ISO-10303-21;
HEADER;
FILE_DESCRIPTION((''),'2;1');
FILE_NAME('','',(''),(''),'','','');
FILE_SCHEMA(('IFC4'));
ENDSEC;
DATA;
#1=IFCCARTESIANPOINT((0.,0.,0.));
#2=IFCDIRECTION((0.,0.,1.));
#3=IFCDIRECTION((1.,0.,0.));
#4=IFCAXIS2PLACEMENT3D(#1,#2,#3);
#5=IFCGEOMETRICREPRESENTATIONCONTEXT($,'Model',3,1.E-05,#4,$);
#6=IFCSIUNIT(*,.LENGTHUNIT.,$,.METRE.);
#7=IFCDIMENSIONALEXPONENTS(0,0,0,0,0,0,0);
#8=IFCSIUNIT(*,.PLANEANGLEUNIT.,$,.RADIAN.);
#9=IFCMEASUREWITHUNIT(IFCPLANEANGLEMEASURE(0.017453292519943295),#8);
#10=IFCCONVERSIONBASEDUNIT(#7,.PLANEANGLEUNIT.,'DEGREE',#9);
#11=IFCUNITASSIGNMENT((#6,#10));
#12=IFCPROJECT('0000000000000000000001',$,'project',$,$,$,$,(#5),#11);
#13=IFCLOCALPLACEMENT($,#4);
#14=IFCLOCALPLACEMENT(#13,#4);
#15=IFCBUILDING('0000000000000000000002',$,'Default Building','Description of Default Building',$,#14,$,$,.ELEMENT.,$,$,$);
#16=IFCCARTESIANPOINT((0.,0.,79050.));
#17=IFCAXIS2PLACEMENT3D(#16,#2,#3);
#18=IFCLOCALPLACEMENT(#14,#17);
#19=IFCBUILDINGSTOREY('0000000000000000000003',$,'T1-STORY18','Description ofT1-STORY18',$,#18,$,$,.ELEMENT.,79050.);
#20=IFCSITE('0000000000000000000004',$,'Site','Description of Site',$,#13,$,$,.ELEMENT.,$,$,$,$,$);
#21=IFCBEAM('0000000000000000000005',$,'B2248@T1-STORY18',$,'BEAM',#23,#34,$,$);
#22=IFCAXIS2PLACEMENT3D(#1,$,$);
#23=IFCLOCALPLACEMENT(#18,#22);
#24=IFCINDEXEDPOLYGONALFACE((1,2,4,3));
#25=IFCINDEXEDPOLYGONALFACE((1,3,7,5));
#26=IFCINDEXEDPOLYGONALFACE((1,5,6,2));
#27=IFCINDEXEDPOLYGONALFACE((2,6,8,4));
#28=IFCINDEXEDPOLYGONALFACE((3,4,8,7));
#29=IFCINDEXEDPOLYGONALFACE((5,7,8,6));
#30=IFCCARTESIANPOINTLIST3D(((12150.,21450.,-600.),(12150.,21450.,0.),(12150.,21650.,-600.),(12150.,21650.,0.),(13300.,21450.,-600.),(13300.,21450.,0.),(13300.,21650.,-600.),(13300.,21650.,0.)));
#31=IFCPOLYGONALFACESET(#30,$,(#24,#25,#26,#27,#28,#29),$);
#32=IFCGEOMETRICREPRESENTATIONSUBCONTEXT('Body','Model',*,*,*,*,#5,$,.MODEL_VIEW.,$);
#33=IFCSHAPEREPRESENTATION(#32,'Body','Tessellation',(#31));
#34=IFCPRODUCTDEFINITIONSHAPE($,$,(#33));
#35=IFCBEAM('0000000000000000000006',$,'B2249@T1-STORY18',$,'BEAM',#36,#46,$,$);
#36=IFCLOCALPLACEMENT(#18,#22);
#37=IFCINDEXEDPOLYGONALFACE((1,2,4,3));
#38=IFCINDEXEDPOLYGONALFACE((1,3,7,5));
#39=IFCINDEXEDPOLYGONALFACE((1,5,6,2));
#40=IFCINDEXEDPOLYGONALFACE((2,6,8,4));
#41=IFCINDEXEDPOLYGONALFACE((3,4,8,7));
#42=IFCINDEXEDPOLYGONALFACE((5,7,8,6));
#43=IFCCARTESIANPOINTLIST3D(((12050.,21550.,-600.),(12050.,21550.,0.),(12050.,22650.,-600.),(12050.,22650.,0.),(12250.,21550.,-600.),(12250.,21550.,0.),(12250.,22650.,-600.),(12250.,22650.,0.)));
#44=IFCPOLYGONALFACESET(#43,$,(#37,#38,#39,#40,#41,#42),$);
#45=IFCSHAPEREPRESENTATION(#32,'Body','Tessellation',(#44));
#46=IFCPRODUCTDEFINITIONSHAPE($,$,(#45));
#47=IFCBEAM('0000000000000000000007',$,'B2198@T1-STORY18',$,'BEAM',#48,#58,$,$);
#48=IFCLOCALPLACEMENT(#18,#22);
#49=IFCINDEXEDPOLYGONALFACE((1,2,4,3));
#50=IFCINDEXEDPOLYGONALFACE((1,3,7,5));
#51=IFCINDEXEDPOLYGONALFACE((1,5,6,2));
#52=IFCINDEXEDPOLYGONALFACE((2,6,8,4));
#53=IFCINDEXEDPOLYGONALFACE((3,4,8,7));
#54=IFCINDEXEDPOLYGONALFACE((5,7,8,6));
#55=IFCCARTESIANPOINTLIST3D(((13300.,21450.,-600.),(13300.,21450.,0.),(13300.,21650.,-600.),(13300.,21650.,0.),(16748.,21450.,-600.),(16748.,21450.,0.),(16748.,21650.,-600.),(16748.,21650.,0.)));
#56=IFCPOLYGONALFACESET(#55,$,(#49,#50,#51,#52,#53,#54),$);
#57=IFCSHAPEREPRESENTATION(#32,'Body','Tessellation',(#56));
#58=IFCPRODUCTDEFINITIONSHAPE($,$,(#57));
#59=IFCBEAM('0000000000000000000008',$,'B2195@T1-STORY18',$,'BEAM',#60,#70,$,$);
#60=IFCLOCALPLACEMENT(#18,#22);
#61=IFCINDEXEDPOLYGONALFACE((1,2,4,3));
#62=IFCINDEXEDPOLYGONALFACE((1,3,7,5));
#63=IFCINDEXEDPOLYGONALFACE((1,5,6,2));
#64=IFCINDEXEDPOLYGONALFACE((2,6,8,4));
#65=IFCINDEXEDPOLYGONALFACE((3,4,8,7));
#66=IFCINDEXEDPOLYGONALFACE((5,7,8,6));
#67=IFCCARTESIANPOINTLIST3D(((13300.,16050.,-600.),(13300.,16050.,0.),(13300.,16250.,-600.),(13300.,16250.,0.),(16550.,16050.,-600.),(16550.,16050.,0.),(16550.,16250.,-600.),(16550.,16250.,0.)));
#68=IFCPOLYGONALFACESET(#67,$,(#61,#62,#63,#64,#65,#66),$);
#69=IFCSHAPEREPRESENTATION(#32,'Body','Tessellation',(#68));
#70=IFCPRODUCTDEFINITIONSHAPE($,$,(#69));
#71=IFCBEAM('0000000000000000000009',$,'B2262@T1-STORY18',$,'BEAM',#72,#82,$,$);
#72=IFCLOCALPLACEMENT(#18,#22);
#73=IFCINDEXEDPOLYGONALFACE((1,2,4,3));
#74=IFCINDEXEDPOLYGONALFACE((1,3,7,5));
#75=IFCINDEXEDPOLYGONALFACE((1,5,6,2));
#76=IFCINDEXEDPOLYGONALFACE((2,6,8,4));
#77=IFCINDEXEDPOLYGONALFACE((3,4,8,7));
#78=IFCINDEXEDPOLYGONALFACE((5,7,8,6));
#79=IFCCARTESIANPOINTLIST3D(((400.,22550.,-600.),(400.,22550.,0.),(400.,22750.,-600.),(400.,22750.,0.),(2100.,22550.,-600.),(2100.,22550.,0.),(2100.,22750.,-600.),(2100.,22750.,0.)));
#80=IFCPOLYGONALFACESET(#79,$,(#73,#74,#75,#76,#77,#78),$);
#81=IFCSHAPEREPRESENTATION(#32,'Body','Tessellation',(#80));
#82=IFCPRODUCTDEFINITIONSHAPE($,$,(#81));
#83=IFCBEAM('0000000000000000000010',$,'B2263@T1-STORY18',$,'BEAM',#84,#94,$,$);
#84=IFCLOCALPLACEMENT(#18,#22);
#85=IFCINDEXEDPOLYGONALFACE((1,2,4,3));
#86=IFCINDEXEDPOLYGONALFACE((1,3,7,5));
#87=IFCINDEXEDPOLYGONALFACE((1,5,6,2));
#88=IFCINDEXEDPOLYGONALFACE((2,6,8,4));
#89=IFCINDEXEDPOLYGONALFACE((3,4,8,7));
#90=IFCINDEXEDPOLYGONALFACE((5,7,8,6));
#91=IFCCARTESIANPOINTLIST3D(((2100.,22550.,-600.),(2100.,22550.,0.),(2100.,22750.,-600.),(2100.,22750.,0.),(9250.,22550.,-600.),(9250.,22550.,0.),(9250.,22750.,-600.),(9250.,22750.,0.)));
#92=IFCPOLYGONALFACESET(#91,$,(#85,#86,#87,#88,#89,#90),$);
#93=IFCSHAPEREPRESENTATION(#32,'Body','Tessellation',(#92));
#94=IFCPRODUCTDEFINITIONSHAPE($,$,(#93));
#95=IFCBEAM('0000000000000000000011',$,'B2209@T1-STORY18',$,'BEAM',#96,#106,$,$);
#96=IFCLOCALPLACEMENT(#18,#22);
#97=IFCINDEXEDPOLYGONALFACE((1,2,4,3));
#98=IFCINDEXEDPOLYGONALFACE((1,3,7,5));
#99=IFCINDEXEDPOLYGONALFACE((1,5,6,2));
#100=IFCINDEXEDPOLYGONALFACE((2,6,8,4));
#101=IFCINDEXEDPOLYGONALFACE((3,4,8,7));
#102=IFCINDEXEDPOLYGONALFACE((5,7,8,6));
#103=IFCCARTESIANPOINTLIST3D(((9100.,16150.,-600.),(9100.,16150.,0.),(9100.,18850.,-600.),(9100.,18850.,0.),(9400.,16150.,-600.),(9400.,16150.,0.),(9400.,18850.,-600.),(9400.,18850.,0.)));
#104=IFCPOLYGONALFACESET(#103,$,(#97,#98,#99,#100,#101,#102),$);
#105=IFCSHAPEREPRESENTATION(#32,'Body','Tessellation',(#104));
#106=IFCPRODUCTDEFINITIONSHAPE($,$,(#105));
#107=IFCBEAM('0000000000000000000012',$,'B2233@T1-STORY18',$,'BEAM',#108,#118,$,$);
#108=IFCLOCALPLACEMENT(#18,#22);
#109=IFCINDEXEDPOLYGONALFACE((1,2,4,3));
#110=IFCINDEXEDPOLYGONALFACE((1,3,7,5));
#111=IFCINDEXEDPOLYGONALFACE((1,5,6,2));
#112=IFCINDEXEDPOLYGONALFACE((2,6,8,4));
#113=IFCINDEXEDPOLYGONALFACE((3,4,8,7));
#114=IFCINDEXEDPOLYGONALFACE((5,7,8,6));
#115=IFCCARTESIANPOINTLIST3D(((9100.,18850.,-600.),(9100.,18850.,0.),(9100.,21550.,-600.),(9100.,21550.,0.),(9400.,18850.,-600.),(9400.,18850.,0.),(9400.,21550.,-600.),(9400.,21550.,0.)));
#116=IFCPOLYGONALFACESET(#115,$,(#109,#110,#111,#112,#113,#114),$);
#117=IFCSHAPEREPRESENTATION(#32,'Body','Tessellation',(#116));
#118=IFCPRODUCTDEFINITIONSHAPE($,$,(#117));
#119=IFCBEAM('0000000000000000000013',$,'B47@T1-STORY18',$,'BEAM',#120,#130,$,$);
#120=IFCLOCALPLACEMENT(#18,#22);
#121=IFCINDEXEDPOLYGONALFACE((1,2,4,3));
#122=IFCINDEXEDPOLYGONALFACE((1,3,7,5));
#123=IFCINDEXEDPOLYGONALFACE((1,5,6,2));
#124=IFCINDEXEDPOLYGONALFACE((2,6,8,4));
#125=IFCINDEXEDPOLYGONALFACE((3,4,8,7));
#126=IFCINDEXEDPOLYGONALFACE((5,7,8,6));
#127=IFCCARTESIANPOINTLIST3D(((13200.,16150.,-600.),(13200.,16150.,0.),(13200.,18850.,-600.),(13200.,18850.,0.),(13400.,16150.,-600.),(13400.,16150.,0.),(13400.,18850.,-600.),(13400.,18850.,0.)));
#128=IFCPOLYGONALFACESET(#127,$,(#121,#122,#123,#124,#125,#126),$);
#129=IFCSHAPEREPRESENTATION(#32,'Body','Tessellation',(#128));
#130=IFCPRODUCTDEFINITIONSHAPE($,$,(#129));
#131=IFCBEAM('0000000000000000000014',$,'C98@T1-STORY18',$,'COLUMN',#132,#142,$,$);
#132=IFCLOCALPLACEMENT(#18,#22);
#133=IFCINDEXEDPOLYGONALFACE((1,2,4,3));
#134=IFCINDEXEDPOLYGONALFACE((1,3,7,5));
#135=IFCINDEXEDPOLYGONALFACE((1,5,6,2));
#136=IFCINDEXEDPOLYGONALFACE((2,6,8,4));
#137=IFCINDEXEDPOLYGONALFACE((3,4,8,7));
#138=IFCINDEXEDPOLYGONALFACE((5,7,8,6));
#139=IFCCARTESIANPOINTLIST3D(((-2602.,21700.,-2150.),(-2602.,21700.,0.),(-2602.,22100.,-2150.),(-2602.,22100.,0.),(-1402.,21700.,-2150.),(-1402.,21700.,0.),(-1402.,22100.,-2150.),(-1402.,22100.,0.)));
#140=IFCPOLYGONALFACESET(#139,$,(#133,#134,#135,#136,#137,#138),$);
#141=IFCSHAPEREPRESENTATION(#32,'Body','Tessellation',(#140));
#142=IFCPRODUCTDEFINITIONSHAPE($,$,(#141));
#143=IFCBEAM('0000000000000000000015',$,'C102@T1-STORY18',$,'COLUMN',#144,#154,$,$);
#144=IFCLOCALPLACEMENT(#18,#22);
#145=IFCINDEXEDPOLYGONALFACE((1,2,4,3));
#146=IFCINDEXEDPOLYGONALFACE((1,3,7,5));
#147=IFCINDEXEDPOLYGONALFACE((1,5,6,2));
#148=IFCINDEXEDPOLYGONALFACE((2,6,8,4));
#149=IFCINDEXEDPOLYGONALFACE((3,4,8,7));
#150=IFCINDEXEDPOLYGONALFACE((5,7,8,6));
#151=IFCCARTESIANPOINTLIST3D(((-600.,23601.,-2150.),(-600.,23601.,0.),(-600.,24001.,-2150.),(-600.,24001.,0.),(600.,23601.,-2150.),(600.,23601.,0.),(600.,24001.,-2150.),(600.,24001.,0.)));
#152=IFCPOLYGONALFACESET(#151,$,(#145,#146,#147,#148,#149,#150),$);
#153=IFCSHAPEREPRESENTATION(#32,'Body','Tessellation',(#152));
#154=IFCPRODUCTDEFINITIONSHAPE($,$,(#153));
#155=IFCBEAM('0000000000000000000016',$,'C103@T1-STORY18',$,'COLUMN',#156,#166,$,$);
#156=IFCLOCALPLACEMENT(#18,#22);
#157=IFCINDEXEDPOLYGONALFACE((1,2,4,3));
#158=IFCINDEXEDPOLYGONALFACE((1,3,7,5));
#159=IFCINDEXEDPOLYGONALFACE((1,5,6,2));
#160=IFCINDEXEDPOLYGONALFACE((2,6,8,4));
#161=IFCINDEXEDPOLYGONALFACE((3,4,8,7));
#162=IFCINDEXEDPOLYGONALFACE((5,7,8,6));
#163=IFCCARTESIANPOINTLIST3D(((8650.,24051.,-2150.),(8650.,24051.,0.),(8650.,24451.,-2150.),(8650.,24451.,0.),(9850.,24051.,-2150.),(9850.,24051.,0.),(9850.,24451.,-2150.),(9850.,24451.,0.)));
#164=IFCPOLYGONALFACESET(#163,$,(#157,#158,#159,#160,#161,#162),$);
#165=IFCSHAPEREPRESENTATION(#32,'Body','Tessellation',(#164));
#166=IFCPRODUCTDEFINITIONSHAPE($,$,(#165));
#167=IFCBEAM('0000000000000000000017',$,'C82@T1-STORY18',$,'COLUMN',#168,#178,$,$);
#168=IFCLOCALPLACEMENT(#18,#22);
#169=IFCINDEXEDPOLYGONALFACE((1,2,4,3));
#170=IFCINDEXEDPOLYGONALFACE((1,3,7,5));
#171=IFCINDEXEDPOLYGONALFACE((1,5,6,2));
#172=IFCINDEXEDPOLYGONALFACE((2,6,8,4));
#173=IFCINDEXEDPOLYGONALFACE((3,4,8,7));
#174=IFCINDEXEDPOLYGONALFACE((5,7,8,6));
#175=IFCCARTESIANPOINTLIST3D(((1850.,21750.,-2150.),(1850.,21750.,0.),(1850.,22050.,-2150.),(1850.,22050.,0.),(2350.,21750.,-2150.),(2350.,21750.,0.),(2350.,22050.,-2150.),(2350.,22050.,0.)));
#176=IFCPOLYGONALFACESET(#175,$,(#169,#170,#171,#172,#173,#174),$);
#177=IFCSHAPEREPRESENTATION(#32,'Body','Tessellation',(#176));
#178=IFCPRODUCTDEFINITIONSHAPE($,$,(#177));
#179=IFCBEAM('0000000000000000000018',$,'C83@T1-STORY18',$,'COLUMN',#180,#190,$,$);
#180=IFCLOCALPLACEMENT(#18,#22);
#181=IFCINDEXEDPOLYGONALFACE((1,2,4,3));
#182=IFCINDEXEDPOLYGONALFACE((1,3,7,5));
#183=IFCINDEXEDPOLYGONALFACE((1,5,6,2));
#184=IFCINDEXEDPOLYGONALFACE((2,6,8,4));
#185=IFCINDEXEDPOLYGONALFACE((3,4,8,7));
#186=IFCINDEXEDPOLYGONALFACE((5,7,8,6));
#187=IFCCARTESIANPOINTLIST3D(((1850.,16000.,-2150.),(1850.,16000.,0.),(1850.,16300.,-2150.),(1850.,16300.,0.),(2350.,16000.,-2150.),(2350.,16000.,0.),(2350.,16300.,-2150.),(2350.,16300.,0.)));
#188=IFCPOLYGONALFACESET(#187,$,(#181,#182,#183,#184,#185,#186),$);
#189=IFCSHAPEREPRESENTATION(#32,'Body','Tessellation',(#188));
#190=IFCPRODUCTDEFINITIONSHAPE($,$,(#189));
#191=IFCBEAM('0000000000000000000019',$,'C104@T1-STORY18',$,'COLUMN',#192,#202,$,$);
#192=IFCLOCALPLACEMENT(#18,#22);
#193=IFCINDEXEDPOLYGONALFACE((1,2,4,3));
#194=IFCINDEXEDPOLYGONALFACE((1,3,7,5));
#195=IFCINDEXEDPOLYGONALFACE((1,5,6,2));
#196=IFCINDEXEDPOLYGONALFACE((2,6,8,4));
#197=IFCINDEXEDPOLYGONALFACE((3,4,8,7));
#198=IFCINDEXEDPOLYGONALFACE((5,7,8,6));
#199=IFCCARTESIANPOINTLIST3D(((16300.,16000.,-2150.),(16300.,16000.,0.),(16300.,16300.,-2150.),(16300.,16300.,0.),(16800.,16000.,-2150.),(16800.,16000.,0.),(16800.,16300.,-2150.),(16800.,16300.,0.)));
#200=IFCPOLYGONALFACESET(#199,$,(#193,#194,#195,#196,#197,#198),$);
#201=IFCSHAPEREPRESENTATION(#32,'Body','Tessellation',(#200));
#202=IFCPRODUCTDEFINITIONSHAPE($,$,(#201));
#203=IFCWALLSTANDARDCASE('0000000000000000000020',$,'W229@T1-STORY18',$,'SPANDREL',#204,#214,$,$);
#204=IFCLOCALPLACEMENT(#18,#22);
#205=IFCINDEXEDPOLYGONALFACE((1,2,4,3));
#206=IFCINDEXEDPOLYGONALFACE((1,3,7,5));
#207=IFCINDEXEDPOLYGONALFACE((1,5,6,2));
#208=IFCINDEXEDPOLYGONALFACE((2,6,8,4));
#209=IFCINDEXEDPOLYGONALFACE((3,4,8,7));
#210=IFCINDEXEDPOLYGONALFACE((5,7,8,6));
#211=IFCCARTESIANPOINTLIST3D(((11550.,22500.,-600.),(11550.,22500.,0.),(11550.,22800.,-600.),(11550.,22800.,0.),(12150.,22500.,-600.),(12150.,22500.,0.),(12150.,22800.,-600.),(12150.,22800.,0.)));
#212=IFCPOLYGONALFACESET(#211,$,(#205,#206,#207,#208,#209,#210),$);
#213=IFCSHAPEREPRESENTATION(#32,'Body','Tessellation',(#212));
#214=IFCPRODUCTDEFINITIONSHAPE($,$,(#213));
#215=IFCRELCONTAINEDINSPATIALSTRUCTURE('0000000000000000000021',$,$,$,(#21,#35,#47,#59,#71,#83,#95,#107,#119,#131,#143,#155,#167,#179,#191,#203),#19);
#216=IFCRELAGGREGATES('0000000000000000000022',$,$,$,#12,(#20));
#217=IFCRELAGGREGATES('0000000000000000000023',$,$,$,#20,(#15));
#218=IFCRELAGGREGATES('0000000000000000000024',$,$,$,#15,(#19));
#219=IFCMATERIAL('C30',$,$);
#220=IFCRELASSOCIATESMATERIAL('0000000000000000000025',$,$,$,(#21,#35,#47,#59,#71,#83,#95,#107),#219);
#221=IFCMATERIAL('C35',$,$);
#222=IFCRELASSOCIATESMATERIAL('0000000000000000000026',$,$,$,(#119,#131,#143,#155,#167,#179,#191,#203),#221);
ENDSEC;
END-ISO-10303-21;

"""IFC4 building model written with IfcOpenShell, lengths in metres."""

from ifc_helpers import new_model, entity, si_unit, converted_unit, frame, origin_with_axes, place, context, subcontext, project, spatial, indexed_curve, rectangle, outline, extrude, material, element, save


model = new_model("IFC4")

# Units and contexts
model_context = context("Model", 3, precision=1e-05, world=origin_with_axes())
body_context = subcontext(model_context, "Body", "Model", "MODEL_VIEW")
ifc_project = project(units=[si_unit("LENGTHUNIT", "METRE"), converted_unit("PLANEANGLEUNIT", "DEGREE", entity("IfcPlaneAngleMeasure", 0.017453292519943295), si_unit("PLANEANGLEUNIT", "RADIAN"), dimensions=[0, 0, 0, 0, 0, 0, 0])], contexts=[model_context])

# Site, building, storey
site_placement = place(None, origin_with_axes())
site = spatial("IfcSite", under=ifc_project, at=site_placement, Name="Site", Description="Description of Site", CompositionType="ELEMENT")
building_placement = place(site_placement, origin_with_axes())
building = spatial("IfcBuilding", under=site, at=building_placement, Name="Default Building", Description="Description of Default Building", CompositionType="ELEMENT")
storey_placement = place(building_placement, frame((0.0, 0.0, 79050.0), z_axis=(0.0, 0.0, 1.0), x_axis=(1.0, 0.0, 0.0)))
storey = spatial("IfcBuildingStorey", under=building, at=storey_placement, Name="T1-STORY18", Description="Description ofT1-STORY18", CompositionType="ELEMENT", Elevation=79050.0)

# Beams
ifc_material_1 = material(Name="C30")
beam_1_placement = place(storey_placement, frame((12150.0, 21550.0, -300.0), z_axis=(1.0, 0.0, 0.0), x_axis=(0.0, 1.0, 0.0)))
element("IfcBeam", 1, at=beam_1_placement, inside=storey, material=ifc_material_1, Name="B2248@T1-STORY18", ObjectType="BEAM", context=body_context, shape_type="SweptSolid", body=[
    extrude(rectangle(XDim=200.0, YDim=600.0), origin_with_axes(), (0.0, 0.0, 1.0), 1150.0),
])
beam_2_placement = place(storey_placement, frame((12150.0, 21550.0, -300.0), z_axis=(0.0, 1.0, 0.0), x_axis=(-1.0, 0.0, 0.0)))
element("IfcBeam", 2, at=beam_2_placement, inside=storey, material=ifc_material_1, Name="B2249@T1-STORY18", ObjectType="BEAM", context=body_context, shape_type="SweptSolid", body=[
    extrude(rectangle(XDim=200.0, YDim=600.0), origin_with_axes(), (0.0, 0.0, 1.0), 1100.0),
])
beam_3_placement = place(storey_placement, frame((13300.0, 21550.0, -300.0), z_axis=(1.0, 0.0, 0.0), x_axis=(0.0, 1.0, 0.0)))
element("IfcBeam", 3, at=beam_3_placement, inside=storey, material=ifc_material_1, Name="B2198@T1-STORY18", ObjectType="BEAM", context=body_context, shape_type="SweptSolid", body=[
    extrude(rectangle(XDim=200.0, YDim=600.0), origin_with_axes(), (0.0, 0.0, 1.0), 3448.0),
])
beam_4_placement = place(storey_placement, frame((13300.0, 16150.0, -300.0), z_axis=(1.0, 0.0, 0.0), x_axis=(0.0, 1.0, 0.0)))
element("IfcBeam", 4, at=beam_4_placement, inside=storey, material=ifc_material_1, Name="B2195@T1-STORY18", ObjectType="BEAM", context=body_context, shape_type="SweptSolid", body=[
    extrude(rectangle(XDim=200.0, YDim=600.0), origin_with_axes(), (0.0, 0.0, 1.0), 3250.0),
])
beam_5_placement = place(storey_placement, frame((400.0, 22650.0, -300.0), z_axis=(1.0, 0.0, 0.0), x_axis=(0.0, 1.0, 0.0)))
element("IfcBeam", 5, at=beam_5_placement, inside=storey, material=ifc_material_1, Name="B2262@T1-STORY18", ObjectType="BEAM", context=body_context, shape_type="SweptSolid", body=[
    extrude(rectangle(XDim=200.0, YDim=600.0), origin_with_axes(), (0.0, 0.0, 1.0), 1700.0),
])
beam_6_placement = place(storey_placement, frame((2100.0, 22650.0, -300.0), z_axis=(1.0, 0.0, 0.0), x_axis=(0.0, 1.0, 0.0)))
element("IfcBeam", 6, at=beam_6_placement, inside=storey, material=ifc_material_1, Name="B2263@T1-STORY18", ObjectType="BEAM", context=body_context, shape_type="SweptSolid", body=[
    extrude(rectangle(XDim=200.0, YDim=600.0), origin_with_axes(), (0.0, 0.0, 1.0), 7150.0),
])
for number, where, z_axis, x_axis, name in (
    (7, (9250.0, 16150.0, -300.0), (0.0, 1.0, 0.0), (-1.0, 0.0, 0.0), "B2209@T1-STORY18"),
    (8, (9250.0, 18850.0, -300.0), (0.0, 1.0, 0.0), (-1.0, 0.0, 0.0), "B2233@T1-STORY18"),
):
    element("IfcBeam", number, at=place(storey_placement, frame(where, z_axis=z_axis, x_axis=x_axis)), inside=storey, material=ifc_material_1, Name=name, ObjectType="BEAM", context=body_context, shape_type="SweptSolid", body=[
        extrude(rectangle(XDim=300.0, YDim=600.0), origin_with_axes(), (0.0, 0.0, 1.0), 2700.0),
    ])
ifc_material_2 = material(Name="C35")
beam_7_placement = place(storey_placement, frame((13300.0, 16150.0, -300.0), z_axis=(0.0, 1.0, 0.0), x_axis=(-1.0, 0.0, 0.0)))
element("IfcBeam", 9, at=beam_7_placement, inside=storey, material=ifc_material_2, Name="B47@T1-STORY18", ObjectType="BEAM", context=body_context, shape_type="SweptSolid", body=[
    extrude(rectangle(XDim=200.0, YDim=600.0), origin_with_axes(), (0.0, 0.0, 1.0), 2700.0),
])
for number, where, z_axis, x_axis, name in (
    (10, (-2002.0, 21900.0, -2150.0), (0.0, 0.0, 1.0), (0.0, -1.0, 0.0), "C98@T1-STORY18"),
    (11, (0.0, 23801.0, -2150.0), (0.0, 0.0, 1.0), (0.0, -1.0, 0.0), "C102@T1-STORY18"),
    (12, (9250.0, 24251.0, -2150.0), (0.0, 0.0, 1.0), (0.0, -1.0, 0.0), "C103@T1-STORY18"),
):
    element("IfcBeam", number, at=place(storey_placement, frame(where, z_axis=z_axis, x_axis=x_axis)), inside=storey, material=ifc_material_2, Name=name, ObjectType="COLUMN", context=body_context, shape_type="SweptSolid", body=[
        extrude(rectangle(XDim=400.0, YDim=1200.0), origin_with_axes(), (0.0, 0.0, 1.0), 2150.0),
    ])
for number, where, z_axis, x_axis, name in (
    (13, (2100.0, 21900.0, -2150.0), (0.0, 0.0, 1.0), (0.0, -1.0, 0.0), "C82@T1-STORY18"),
    (14, (2100.0, 16150.0, -2150.0), (0.0, 0.0, 1.0), (0.0, -1.0, 0.0), "C83@T1-STORY18"),
    (15, (16550.0, 16150.0, -2150.0), (0.0, 0.0, 1.0), (0.0, -1.0, 0.0), "C104@T1-STORY18"),
):
    element("IfcBeam", number, at=place(storey_placement, frame(where, z_axis=z_axis, x_axis=x_axis)), inside=storey, material=ifc_material_2, Name=name, ObjectType="COLUMN", context=body_context, shape_type="SweptSolid", body=[
        extrude(rectangle(XDim=300.0, YDim=500.0), origin_with_axes(), (0.0, 0.0, 1.0), 2150.0),
    ])

# Wall
for number, where, z_axis, x_axis, name in (
    (16, (11550.0, 22650.0, -600.0), (0.0, 0.0, 1.0), (1.0, 0.0, 0.0), "W229@T1-STORY18"),
):
    element("IfcWallStandardCase", number, at=place(storey_placement, frame(where, z_axis=z_axis, x_axis=x_axis)), inside=storey, material=ifc_material_2, Name=name, ObjectType="SPANDREL", context=body_context, shape_type="SweptSolid", body=[
        extrude(outline(indexed_curve([(0.0, -150.0), (0.0, 150.0), (600.0, 150.0), (600.0, -150.0), (0.0, -150.0)], self_intersect=False)), origin_with_axes(), (0.0, 0.0, 1.0), 600.0),
    ])

save(model, "model.ifc")
